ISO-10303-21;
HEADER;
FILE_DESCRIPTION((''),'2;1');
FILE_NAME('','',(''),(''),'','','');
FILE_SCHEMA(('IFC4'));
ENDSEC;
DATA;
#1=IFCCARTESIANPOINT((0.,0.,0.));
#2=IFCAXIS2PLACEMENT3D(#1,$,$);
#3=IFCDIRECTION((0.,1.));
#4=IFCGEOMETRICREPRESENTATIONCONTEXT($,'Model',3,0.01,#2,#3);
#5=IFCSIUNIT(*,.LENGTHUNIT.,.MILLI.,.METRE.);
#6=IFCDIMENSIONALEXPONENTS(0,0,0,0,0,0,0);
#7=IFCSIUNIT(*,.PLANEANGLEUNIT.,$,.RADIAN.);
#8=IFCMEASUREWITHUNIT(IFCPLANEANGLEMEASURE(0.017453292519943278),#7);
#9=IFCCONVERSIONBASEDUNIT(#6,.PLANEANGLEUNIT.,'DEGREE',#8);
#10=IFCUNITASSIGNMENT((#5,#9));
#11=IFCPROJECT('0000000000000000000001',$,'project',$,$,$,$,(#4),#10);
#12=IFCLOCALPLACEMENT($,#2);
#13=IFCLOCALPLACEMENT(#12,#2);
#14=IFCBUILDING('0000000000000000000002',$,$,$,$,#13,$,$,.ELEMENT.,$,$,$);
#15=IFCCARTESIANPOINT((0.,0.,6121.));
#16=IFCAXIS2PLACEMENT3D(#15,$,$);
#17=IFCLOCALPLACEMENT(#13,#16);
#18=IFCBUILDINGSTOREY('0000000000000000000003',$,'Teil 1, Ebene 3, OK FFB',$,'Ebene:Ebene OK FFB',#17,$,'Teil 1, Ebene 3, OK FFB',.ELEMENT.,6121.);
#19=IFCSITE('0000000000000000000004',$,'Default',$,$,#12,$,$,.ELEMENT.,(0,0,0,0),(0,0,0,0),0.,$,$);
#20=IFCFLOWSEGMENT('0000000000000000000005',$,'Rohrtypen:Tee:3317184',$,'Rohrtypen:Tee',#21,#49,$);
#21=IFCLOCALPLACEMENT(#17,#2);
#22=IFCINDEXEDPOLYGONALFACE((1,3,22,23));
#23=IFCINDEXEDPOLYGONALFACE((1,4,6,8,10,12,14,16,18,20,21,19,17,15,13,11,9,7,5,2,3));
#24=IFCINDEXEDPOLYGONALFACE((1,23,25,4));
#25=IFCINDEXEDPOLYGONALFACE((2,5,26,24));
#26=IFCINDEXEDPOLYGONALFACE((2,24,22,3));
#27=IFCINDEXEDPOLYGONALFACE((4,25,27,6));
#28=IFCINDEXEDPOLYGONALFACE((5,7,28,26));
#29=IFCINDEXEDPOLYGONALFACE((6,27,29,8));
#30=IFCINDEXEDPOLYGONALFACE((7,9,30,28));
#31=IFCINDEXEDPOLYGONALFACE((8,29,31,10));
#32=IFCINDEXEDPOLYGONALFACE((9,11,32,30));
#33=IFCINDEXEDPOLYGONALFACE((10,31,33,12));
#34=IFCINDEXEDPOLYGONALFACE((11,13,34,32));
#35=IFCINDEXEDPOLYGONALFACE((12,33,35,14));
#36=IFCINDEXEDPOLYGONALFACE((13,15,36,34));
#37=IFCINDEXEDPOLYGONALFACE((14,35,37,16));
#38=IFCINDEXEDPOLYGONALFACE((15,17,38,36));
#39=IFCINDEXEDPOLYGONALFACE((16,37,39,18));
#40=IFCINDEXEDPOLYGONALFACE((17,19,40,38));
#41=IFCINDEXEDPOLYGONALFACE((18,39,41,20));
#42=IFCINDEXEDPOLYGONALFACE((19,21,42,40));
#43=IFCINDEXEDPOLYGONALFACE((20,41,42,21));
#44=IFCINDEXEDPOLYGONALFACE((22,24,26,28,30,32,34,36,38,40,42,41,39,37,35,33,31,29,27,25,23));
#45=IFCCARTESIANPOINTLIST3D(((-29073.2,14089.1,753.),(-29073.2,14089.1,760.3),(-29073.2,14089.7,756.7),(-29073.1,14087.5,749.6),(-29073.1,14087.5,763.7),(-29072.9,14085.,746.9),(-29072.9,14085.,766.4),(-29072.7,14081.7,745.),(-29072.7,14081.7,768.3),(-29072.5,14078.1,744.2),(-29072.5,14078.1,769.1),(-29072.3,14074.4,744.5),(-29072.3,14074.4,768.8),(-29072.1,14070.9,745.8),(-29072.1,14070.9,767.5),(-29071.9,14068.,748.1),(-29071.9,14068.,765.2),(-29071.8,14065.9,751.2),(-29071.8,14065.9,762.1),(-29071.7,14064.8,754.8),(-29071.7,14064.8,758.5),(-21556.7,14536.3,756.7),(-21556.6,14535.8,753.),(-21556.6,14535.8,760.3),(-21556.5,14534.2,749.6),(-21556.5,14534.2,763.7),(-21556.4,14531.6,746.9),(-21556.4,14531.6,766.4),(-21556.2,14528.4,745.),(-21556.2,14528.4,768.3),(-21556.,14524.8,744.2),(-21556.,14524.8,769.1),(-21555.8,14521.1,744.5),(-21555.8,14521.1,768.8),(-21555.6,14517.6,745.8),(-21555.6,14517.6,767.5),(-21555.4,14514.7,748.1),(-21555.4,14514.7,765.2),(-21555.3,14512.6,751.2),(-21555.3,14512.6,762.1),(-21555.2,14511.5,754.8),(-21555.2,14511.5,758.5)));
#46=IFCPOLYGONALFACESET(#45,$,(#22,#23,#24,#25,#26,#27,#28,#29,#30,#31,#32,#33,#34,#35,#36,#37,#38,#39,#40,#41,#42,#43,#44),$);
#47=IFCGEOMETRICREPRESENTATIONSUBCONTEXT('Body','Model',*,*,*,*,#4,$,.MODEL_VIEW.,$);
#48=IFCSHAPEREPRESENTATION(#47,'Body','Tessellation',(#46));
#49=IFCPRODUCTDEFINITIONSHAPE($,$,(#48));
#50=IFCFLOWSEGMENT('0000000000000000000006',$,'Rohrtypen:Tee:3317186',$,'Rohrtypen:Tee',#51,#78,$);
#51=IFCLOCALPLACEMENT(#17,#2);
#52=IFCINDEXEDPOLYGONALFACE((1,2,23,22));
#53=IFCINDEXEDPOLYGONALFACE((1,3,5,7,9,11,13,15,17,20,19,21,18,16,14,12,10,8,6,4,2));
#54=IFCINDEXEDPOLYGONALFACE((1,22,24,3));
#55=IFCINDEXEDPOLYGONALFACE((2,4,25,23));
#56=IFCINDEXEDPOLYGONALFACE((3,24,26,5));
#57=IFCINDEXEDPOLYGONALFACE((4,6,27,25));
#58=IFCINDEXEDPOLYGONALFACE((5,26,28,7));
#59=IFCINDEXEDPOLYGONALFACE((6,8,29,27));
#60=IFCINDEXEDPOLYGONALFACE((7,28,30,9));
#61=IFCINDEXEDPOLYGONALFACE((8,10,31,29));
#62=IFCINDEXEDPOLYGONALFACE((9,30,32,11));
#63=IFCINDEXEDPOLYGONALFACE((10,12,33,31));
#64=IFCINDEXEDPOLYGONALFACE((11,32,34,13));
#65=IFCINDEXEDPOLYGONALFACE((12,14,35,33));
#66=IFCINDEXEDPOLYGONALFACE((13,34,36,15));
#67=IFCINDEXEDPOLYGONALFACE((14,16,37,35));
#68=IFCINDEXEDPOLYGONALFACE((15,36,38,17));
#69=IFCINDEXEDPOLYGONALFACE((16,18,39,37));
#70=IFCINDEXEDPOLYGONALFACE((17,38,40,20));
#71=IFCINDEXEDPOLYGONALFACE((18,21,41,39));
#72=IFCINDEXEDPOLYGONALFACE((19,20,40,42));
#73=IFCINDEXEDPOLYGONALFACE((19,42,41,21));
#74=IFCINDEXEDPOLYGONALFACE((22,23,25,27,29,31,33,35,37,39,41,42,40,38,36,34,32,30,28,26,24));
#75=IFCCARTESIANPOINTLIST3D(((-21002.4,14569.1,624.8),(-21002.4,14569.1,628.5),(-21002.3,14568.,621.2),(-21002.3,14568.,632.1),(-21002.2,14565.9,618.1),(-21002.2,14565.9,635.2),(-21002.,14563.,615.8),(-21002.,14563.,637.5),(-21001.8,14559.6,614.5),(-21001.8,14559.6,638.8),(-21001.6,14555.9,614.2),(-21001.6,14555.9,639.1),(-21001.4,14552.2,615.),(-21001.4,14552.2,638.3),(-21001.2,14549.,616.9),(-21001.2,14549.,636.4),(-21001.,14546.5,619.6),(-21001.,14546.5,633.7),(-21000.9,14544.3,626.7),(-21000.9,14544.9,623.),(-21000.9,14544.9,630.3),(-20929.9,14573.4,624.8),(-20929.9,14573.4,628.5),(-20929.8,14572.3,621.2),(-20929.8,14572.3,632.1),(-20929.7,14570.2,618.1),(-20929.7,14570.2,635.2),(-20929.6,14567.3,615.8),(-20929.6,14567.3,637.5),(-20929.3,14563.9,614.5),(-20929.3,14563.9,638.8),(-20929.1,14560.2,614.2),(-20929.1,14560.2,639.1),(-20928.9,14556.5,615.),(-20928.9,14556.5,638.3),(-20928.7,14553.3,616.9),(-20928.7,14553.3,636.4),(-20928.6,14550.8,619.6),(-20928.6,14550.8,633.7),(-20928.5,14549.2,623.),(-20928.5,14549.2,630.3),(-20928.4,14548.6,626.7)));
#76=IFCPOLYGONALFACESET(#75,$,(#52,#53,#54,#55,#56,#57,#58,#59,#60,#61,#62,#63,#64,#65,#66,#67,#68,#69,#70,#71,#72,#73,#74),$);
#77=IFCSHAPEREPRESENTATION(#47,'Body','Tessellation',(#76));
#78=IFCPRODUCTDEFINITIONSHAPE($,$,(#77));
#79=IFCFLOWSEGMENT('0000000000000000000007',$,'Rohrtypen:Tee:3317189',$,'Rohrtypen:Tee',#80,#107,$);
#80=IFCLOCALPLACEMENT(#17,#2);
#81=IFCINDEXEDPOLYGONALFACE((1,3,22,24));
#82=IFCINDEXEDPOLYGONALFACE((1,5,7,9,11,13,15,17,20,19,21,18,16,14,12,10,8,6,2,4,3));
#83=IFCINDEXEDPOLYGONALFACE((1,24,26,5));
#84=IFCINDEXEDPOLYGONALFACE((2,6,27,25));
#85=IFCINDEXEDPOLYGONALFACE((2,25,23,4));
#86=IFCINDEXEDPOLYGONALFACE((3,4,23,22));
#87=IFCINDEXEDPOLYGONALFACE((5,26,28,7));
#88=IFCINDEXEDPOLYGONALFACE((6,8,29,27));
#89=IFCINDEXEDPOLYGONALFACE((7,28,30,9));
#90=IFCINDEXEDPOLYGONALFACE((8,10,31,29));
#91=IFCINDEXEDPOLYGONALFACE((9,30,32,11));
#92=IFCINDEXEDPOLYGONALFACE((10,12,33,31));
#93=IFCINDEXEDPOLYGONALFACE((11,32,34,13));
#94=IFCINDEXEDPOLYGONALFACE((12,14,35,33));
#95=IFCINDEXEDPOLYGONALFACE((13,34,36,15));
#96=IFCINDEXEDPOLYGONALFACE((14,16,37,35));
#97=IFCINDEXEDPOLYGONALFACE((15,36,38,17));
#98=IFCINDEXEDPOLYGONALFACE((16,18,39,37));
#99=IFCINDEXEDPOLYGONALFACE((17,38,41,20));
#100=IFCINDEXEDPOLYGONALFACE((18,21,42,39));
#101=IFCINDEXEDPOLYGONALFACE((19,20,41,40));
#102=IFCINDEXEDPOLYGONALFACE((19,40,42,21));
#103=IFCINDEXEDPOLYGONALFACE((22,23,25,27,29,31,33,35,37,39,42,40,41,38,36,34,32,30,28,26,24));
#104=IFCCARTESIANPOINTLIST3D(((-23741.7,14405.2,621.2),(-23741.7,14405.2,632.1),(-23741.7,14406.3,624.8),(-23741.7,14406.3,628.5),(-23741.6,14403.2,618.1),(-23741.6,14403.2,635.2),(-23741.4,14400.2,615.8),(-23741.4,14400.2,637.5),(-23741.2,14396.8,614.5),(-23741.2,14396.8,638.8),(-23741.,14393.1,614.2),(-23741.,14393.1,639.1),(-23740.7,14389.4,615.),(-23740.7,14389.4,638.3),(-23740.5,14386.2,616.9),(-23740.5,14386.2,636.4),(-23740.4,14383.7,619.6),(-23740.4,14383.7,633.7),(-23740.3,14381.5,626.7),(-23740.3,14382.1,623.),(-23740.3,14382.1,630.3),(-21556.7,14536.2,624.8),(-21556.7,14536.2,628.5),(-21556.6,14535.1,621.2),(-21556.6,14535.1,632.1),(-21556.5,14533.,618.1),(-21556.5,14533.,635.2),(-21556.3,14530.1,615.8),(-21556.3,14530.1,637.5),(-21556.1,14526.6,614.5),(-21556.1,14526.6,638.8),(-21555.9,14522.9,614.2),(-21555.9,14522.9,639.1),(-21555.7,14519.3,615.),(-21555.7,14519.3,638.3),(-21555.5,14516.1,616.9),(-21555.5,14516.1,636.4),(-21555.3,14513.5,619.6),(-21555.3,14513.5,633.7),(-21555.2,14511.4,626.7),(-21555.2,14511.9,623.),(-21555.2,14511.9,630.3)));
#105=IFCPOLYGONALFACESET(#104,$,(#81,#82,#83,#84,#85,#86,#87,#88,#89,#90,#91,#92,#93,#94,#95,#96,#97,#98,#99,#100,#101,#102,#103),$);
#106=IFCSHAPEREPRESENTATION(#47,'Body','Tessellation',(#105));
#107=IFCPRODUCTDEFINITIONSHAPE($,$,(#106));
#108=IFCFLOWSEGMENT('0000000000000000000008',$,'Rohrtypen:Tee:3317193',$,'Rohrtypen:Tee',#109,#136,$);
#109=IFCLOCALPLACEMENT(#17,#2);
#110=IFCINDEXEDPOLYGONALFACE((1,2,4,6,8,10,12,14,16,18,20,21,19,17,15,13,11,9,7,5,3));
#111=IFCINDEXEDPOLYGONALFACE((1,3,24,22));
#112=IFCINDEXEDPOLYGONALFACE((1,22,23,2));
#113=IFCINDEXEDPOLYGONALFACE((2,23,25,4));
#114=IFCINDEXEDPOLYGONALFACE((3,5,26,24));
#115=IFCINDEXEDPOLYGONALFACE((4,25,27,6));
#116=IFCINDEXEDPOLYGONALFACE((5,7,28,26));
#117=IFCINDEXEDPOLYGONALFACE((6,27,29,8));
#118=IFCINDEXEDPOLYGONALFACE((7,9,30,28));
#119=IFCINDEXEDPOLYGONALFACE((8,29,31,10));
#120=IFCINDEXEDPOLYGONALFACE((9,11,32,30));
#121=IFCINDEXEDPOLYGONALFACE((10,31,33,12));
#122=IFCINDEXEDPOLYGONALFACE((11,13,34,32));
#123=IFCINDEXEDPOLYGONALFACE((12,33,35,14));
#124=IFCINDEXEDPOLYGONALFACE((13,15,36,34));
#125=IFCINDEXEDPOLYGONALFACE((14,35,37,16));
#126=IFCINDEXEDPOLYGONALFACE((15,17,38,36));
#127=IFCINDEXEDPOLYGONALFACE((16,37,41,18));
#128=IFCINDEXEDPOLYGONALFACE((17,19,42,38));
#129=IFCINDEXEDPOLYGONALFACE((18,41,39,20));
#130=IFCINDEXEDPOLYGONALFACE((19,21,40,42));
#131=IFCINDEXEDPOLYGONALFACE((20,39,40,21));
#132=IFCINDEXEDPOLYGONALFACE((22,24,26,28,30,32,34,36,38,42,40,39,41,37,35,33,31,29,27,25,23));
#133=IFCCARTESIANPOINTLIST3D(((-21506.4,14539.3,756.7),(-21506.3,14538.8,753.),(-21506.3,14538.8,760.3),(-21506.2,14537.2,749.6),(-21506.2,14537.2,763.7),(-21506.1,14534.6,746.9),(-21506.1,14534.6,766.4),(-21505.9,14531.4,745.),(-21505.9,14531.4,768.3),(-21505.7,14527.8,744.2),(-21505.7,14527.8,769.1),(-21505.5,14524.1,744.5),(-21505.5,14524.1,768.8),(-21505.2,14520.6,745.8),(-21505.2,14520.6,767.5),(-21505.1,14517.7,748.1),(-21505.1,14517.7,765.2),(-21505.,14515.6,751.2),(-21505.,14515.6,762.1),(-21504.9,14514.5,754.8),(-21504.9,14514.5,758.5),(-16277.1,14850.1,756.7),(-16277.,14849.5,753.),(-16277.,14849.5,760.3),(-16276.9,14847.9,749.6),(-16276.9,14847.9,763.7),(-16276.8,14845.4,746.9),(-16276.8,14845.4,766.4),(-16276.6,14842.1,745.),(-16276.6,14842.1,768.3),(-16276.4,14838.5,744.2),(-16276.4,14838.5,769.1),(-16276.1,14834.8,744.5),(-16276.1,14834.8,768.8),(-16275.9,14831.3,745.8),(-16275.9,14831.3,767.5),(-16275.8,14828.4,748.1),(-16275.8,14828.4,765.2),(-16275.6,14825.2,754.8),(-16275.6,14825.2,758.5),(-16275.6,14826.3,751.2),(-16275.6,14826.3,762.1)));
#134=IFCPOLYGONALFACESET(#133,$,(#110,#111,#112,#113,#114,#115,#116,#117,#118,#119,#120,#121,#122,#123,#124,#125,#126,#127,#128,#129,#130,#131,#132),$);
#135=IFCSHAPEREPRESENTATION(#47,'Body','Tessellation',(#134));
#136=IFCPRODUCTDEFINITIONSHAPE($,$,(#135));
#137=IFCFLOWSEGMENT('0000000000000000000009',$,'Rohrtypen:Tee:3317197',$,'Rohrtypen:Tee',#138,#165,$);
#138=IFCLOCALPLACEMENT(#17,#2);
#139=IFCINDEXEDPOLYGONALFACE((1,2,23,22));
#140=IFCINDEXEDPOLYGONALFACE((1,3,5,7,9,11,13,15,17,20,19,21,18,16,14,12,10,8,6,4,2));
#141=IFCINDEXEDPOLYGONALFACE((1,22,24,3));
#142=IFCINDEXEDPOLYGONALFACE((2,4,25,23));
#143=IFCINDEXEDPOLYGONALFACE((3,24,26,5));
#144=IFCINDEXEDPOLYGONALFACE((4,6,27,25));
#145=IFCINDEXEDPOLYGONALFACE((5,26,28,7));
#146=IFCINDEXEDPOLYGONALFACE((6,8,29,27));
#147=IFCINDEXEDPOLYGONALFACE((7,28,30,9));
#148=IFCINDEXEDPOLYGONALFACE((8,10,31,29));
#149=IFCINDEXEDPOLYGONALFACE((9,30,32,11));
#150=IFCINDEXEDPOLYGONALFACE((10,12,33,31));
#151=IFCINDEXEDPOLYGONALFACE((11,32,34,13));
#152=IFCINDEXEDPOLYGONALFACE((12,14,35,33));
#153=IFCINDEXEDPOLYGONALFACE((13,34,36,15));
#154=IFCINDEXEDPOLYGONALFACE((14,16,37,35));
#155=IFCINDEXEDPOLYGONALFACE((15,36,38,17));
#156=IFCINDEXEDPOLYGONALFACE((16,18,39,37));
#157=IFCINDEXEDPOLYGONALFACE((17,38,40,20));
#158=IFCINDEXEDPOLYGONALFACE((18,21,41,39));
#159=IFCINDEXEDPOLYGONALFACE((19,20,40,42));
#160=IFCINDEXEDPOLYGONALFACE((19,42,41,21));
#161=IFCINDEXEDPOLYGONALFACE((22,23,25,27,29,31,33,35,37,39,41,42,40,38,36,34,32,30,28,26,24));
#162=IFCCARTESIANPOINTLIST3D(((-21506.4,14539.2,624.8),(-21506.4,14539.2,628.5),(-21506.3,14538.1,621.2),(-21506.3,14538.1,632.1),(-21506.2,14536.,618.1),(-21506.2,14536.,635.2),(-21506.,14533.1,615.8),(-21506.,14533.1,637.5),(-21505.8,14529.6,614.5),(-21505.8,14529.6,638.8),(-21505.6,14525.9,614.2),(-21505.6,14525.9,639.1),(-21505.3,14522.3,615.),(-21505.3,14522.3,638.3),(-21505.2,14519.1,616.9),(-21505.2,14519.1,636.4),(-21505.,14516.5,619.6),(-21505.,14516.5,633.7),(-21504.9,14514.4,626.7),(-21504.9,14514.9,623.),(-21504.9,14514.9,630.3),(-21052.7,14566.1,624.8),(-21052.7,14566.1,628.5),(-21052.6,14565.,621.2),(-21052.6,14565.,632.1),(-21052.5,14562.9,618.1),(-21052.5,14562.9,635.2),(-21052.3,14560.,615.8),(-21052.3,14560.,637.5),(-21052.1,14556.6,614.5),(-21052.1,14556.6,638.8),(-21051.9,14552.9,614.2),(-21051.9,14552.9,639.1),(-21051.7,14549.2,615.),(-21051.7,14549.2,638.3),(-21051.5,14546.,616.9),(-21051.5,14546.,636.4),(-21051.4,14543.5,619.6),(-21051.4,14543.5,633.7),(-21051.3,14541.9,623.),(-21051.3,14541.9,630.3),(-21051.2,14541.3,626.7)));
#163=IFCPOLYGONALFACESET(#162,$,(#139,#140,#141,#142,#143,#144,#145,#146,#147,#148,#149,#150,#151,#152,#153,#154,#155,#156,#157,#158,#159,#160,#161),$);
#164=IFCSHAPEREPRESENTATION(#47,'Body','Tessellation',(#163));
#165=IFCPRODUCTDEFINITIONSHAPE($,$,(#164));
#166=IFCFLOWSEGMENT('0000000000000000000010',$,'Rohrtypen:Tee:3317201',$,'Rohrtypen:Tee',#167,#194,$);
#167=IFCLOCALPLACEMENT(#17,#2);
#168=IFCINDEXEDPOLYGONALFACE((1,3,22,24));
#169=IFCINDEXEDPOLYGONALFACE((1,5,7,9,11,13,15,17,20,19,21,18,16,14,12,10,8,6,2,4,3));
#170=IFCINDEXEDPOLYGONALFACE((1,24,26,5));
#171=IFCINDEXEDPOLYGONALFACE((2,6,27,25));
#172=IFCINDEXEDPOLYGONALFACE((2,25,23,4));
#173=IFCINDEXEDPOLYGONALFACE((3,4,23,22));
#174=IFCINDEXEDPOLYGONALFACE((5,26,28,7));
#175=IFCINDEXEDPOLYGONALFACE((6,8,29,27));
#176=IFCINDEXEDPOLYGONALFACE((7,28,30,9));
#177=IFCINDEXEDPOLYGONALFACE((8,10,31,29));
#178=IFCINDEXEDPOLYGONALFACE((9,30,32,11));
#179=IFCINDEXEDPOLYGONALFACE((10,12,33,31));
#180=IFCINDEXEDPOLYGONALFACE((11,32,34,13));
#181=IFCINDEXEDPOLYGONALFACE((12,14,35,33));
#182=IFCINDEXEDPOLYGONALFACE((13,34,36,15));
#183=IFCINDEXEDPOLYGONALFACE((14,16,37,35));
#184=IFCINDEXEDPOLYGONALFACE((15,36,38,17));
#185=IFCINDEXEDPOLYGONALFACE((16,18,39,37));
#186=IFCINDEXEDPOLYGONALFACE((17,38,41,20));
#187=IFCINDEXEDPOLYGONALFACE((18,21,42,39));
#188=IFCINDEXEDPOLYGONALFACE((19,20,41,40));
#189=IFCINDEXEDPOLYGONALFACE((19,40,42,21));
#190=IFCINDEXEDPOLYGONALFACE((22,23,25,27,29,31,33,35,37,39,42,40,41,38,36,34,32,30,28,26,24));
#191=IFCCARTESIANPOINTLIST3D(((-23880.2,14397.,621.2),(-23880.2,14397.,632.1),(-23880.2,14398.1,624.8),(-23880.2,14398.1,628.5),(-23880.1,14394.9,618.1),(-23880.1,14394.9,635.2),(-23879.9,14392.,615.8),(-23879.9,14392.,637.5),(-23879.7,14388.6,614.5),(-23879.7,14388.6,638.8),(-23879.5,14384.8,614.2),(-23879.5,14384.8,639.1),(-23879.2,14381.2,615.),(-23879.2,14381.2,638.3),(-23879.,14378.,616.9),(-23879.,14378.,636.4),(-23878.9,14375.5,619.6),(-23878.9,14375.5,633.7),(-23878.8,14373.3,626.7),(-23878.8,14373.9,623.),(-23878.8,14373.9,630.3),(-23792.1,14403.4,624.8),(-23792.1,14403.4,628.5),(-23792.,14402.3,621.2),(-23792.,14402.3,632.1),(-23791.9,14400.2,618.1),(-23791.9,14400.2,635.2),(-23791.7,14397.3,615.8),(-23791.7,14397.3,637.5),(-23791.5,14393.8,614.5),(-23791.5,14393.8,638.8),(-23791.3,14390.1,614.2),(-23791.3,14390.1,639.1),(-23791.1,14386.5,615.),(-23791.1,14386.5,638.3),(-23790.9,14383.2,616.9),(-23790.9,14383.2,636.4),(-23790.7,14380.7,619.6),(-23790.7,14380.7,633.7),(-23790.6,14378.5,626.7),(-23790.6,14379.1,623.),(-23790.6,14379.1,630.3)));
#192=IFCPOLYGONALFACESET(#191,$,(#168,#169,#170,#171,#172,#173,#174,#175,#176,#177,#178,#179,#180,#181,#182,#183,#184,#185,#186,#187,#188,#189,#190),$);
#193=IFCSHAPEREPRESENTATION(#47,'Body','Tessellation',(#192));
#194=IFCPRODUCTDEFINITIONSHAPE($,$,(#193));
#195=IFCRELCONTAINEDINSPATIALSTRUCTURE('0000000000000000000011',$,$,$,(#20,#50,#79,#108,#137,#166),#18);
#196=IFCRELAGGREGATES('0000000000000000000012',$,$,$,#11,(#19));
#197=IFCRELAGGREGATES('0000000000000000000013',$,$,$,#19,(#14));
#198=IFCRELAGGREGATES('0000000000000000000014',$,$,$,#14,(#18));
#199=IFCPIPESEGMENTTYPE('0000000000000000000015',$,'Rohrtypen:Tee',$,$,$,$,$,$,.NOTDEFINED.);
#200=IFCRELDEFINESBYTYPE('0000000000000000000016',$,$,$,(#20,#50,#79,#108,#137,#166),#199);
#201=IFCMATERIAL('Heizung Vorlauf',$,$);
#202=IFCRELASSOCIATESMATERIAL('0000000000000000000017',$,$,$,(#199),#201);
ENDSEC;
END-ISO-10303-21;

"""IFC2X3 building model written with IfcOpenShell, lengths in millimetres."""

from ifc_helpers import new_model, entity, si_unit, converted_unit, direction, frame, frame_2d, origin, origin_2d_with_axis, place, context, subcontext, project, spatial, circle, extrude, material, type_object, element, save


model = new_model("IFC2X3")

# Units and contexts
model_context = context("Model", 3, precision=0.01, world=origin(), true_north=direction((0.0, 1.0)))
body_context = subcontext(model_context, "Body", "Model", "MODEL_VIEW")
ifc_project = project(units=[si_unit("LENGTHUNIT", "METRE", prefix="MILLI"), converted_unit("PLANEANGLEUNIT", "DEGREE", entity("IfcPlaneAngleMeasure", 0.017453292519943278), si_unit("PLANEANGLEUNIT", "RADIAN"), dimensions=[0, 0, 0, 0, 0, 0, 0])], contexts=[model_context])

# Site, building, storey
site_placement = place(None, origin())
site = spatial("IfcSite", under=ifc_project, at=site_placement, Name="Default", CompositionType="ELEMENT", RefLatitude=(0, 0, 0, 0), RefLongitude=(0, 0, 0, 0), RefElevation=0.0)
building_placement = place(site_placement, origin())
building = spatial("IfcBuilding", under=site, at=building_placement, CompositionType="ELEMENT")
storey_placement = place(building_placement, frame((0.0, 0.0, 6121.0)))
storey = spatial("IfcBuildingStorey", under=building, at=storey_placement, Name="Teil 1, Ebene 3, OK FFB", ObjectType="Ebene:Ebene OK FFB", LongName="Teil 1, Ebene 3, OK FFB", CompositionType="ELEMENT", Elevation=6121.0)

# Flow segments
ifc_material = material(Name="Heizung Vorlauf")
pipe_segment_type = type_object("IfcPipeSegmentType", Name="Rohrtypen:Tee", PredefinedType="NOTDEFINED", material=ifc_material)
flow_segment_1_placement = place(storey_placement, origin())
element("IfcFlowSegment", 1, at=flow_segment_1_placement, inside=storey, type_object=pipe_segment_type, Name="Rohrtypen:Tee:3317184", ObjectType="Rohrtypen:Tee", context=body_context, shape_type="SweptSolid", body=[
    extrude(circle(Radius=12.5, at=origin_2d_with_axis()), frame((-29072.5, 14077.2, 756.7), z_axis=(0.998239, 0.059319, 0.0), x_axis=(-0.059319, 0.998239, 0.0)), (0.0, 0.0, 1.0), 7529.8),
])
flow_segment_2_placement = place(storey_placement, origin())
element("IfcFlowSegment", 2, at=flow_segment_2_placement, inside=storey, type_object=pipe_segment_type, Name="Rohrtypen:Tee:3317186", ObjectType="Rohrtypen:Tee", context=body_context, shape_type="SweptSolid", body=[
    extrude(circle(Radius=12.5, at=origin_2d_with_axis()), frame((-21001.7, 14556.8, 626.7), z_axis=(0.998239, 0.059319, 0.0), x_axis=(0.059319, -0.998239, 0.0)), (0.0, 0.0, 1.0), 72.6),
])
flow_segment_3_placement = place(storey_placement, origin())
element("IfcFlowSegment", 3, at=flow_segment_3_placement, inside=storey, type_object=pipe_segment_type, Name="Rohrtypen:Tee:3317189", ObjectType="Rohrtypen:Tee", context=body_context, shape_type="SweptSolid", body=[
    extrude(circle(Radius=12.5, at=origin_2d_with_axis()), frame((-23741.0, 14394.0, 626.7), z_axis=(0.998239, 0.059319, 0.0), x_axis=(0.059319, -0.998239, 0.0)), (0.0, 0.0, 1.0), 2188.9),
])
flow_segment_4_placement = place(storey_placement, origin())
element("IfcFlowSegment", 4, at=flow_segment_4_placement, inside=storey, type_object=pipe_segment_type, Name="Rohrtypen:Tee:3317193", ObjectType="Rohrtypen:Tee", context=body_context, shape_type="SweptSolid", body=[
    extrude(circle(Radius=12.5, at=origin_2d_with_axis()), frame((-21505.6, 14526.8, 756.7), z_axis=(0.998239, 0.059319, 0.0), x_axis=(-0.059319, 0.998239, 0.0)), (0.0, 0.0, 1.0), 5238.5),
])
flow_segment_5_placement = place(storey_placement, origin())
element("IfcFlowSegment", 5, at=flow_segment_5_placement, inside=storey, type_object=pipe_segment_type, Name="Rohrtypen:Tee:3317197", ObjectType="Rohrtypen:Tee", context=body_context, shape_type="SweptSolid", body=[
    extrude(circle(Radius=12.5, at=frame_2d((0.0, 0.0), x_axis=(1.0, 0.0))), frame((-21505.6, 14526.8, 626.7), z_axis=(0.998239, 0.059319, 0.0), x_axis=(0.059319, -0.998239, 0.0)), (0.0, 0.0, 1.0), 454.5),
])
flow_segment_6_placement = place(storey_placement, origin())
element("IfcFlowSegment", 6, at=flow_segment_6_placement, inside=storey, type_object=pipe_segment_type, Name="Rohrtypen:Tee:3317201", ObjectType="Rohrtypen:Tee", context=body_context, shape_type="SweptSolid", body=[
    extrude(circle(Radius=12.5, at=origin_2d_with_axis()), frame((-23879.5, 14385.8, 626.7), z_axis=(0.998239, 0.059319, 0.0), x_axis=(0.059319, -0.998239, 0.0)), (0.0, 0.0, 1.0), 88.3),
])

save(model, "model.ifc")
